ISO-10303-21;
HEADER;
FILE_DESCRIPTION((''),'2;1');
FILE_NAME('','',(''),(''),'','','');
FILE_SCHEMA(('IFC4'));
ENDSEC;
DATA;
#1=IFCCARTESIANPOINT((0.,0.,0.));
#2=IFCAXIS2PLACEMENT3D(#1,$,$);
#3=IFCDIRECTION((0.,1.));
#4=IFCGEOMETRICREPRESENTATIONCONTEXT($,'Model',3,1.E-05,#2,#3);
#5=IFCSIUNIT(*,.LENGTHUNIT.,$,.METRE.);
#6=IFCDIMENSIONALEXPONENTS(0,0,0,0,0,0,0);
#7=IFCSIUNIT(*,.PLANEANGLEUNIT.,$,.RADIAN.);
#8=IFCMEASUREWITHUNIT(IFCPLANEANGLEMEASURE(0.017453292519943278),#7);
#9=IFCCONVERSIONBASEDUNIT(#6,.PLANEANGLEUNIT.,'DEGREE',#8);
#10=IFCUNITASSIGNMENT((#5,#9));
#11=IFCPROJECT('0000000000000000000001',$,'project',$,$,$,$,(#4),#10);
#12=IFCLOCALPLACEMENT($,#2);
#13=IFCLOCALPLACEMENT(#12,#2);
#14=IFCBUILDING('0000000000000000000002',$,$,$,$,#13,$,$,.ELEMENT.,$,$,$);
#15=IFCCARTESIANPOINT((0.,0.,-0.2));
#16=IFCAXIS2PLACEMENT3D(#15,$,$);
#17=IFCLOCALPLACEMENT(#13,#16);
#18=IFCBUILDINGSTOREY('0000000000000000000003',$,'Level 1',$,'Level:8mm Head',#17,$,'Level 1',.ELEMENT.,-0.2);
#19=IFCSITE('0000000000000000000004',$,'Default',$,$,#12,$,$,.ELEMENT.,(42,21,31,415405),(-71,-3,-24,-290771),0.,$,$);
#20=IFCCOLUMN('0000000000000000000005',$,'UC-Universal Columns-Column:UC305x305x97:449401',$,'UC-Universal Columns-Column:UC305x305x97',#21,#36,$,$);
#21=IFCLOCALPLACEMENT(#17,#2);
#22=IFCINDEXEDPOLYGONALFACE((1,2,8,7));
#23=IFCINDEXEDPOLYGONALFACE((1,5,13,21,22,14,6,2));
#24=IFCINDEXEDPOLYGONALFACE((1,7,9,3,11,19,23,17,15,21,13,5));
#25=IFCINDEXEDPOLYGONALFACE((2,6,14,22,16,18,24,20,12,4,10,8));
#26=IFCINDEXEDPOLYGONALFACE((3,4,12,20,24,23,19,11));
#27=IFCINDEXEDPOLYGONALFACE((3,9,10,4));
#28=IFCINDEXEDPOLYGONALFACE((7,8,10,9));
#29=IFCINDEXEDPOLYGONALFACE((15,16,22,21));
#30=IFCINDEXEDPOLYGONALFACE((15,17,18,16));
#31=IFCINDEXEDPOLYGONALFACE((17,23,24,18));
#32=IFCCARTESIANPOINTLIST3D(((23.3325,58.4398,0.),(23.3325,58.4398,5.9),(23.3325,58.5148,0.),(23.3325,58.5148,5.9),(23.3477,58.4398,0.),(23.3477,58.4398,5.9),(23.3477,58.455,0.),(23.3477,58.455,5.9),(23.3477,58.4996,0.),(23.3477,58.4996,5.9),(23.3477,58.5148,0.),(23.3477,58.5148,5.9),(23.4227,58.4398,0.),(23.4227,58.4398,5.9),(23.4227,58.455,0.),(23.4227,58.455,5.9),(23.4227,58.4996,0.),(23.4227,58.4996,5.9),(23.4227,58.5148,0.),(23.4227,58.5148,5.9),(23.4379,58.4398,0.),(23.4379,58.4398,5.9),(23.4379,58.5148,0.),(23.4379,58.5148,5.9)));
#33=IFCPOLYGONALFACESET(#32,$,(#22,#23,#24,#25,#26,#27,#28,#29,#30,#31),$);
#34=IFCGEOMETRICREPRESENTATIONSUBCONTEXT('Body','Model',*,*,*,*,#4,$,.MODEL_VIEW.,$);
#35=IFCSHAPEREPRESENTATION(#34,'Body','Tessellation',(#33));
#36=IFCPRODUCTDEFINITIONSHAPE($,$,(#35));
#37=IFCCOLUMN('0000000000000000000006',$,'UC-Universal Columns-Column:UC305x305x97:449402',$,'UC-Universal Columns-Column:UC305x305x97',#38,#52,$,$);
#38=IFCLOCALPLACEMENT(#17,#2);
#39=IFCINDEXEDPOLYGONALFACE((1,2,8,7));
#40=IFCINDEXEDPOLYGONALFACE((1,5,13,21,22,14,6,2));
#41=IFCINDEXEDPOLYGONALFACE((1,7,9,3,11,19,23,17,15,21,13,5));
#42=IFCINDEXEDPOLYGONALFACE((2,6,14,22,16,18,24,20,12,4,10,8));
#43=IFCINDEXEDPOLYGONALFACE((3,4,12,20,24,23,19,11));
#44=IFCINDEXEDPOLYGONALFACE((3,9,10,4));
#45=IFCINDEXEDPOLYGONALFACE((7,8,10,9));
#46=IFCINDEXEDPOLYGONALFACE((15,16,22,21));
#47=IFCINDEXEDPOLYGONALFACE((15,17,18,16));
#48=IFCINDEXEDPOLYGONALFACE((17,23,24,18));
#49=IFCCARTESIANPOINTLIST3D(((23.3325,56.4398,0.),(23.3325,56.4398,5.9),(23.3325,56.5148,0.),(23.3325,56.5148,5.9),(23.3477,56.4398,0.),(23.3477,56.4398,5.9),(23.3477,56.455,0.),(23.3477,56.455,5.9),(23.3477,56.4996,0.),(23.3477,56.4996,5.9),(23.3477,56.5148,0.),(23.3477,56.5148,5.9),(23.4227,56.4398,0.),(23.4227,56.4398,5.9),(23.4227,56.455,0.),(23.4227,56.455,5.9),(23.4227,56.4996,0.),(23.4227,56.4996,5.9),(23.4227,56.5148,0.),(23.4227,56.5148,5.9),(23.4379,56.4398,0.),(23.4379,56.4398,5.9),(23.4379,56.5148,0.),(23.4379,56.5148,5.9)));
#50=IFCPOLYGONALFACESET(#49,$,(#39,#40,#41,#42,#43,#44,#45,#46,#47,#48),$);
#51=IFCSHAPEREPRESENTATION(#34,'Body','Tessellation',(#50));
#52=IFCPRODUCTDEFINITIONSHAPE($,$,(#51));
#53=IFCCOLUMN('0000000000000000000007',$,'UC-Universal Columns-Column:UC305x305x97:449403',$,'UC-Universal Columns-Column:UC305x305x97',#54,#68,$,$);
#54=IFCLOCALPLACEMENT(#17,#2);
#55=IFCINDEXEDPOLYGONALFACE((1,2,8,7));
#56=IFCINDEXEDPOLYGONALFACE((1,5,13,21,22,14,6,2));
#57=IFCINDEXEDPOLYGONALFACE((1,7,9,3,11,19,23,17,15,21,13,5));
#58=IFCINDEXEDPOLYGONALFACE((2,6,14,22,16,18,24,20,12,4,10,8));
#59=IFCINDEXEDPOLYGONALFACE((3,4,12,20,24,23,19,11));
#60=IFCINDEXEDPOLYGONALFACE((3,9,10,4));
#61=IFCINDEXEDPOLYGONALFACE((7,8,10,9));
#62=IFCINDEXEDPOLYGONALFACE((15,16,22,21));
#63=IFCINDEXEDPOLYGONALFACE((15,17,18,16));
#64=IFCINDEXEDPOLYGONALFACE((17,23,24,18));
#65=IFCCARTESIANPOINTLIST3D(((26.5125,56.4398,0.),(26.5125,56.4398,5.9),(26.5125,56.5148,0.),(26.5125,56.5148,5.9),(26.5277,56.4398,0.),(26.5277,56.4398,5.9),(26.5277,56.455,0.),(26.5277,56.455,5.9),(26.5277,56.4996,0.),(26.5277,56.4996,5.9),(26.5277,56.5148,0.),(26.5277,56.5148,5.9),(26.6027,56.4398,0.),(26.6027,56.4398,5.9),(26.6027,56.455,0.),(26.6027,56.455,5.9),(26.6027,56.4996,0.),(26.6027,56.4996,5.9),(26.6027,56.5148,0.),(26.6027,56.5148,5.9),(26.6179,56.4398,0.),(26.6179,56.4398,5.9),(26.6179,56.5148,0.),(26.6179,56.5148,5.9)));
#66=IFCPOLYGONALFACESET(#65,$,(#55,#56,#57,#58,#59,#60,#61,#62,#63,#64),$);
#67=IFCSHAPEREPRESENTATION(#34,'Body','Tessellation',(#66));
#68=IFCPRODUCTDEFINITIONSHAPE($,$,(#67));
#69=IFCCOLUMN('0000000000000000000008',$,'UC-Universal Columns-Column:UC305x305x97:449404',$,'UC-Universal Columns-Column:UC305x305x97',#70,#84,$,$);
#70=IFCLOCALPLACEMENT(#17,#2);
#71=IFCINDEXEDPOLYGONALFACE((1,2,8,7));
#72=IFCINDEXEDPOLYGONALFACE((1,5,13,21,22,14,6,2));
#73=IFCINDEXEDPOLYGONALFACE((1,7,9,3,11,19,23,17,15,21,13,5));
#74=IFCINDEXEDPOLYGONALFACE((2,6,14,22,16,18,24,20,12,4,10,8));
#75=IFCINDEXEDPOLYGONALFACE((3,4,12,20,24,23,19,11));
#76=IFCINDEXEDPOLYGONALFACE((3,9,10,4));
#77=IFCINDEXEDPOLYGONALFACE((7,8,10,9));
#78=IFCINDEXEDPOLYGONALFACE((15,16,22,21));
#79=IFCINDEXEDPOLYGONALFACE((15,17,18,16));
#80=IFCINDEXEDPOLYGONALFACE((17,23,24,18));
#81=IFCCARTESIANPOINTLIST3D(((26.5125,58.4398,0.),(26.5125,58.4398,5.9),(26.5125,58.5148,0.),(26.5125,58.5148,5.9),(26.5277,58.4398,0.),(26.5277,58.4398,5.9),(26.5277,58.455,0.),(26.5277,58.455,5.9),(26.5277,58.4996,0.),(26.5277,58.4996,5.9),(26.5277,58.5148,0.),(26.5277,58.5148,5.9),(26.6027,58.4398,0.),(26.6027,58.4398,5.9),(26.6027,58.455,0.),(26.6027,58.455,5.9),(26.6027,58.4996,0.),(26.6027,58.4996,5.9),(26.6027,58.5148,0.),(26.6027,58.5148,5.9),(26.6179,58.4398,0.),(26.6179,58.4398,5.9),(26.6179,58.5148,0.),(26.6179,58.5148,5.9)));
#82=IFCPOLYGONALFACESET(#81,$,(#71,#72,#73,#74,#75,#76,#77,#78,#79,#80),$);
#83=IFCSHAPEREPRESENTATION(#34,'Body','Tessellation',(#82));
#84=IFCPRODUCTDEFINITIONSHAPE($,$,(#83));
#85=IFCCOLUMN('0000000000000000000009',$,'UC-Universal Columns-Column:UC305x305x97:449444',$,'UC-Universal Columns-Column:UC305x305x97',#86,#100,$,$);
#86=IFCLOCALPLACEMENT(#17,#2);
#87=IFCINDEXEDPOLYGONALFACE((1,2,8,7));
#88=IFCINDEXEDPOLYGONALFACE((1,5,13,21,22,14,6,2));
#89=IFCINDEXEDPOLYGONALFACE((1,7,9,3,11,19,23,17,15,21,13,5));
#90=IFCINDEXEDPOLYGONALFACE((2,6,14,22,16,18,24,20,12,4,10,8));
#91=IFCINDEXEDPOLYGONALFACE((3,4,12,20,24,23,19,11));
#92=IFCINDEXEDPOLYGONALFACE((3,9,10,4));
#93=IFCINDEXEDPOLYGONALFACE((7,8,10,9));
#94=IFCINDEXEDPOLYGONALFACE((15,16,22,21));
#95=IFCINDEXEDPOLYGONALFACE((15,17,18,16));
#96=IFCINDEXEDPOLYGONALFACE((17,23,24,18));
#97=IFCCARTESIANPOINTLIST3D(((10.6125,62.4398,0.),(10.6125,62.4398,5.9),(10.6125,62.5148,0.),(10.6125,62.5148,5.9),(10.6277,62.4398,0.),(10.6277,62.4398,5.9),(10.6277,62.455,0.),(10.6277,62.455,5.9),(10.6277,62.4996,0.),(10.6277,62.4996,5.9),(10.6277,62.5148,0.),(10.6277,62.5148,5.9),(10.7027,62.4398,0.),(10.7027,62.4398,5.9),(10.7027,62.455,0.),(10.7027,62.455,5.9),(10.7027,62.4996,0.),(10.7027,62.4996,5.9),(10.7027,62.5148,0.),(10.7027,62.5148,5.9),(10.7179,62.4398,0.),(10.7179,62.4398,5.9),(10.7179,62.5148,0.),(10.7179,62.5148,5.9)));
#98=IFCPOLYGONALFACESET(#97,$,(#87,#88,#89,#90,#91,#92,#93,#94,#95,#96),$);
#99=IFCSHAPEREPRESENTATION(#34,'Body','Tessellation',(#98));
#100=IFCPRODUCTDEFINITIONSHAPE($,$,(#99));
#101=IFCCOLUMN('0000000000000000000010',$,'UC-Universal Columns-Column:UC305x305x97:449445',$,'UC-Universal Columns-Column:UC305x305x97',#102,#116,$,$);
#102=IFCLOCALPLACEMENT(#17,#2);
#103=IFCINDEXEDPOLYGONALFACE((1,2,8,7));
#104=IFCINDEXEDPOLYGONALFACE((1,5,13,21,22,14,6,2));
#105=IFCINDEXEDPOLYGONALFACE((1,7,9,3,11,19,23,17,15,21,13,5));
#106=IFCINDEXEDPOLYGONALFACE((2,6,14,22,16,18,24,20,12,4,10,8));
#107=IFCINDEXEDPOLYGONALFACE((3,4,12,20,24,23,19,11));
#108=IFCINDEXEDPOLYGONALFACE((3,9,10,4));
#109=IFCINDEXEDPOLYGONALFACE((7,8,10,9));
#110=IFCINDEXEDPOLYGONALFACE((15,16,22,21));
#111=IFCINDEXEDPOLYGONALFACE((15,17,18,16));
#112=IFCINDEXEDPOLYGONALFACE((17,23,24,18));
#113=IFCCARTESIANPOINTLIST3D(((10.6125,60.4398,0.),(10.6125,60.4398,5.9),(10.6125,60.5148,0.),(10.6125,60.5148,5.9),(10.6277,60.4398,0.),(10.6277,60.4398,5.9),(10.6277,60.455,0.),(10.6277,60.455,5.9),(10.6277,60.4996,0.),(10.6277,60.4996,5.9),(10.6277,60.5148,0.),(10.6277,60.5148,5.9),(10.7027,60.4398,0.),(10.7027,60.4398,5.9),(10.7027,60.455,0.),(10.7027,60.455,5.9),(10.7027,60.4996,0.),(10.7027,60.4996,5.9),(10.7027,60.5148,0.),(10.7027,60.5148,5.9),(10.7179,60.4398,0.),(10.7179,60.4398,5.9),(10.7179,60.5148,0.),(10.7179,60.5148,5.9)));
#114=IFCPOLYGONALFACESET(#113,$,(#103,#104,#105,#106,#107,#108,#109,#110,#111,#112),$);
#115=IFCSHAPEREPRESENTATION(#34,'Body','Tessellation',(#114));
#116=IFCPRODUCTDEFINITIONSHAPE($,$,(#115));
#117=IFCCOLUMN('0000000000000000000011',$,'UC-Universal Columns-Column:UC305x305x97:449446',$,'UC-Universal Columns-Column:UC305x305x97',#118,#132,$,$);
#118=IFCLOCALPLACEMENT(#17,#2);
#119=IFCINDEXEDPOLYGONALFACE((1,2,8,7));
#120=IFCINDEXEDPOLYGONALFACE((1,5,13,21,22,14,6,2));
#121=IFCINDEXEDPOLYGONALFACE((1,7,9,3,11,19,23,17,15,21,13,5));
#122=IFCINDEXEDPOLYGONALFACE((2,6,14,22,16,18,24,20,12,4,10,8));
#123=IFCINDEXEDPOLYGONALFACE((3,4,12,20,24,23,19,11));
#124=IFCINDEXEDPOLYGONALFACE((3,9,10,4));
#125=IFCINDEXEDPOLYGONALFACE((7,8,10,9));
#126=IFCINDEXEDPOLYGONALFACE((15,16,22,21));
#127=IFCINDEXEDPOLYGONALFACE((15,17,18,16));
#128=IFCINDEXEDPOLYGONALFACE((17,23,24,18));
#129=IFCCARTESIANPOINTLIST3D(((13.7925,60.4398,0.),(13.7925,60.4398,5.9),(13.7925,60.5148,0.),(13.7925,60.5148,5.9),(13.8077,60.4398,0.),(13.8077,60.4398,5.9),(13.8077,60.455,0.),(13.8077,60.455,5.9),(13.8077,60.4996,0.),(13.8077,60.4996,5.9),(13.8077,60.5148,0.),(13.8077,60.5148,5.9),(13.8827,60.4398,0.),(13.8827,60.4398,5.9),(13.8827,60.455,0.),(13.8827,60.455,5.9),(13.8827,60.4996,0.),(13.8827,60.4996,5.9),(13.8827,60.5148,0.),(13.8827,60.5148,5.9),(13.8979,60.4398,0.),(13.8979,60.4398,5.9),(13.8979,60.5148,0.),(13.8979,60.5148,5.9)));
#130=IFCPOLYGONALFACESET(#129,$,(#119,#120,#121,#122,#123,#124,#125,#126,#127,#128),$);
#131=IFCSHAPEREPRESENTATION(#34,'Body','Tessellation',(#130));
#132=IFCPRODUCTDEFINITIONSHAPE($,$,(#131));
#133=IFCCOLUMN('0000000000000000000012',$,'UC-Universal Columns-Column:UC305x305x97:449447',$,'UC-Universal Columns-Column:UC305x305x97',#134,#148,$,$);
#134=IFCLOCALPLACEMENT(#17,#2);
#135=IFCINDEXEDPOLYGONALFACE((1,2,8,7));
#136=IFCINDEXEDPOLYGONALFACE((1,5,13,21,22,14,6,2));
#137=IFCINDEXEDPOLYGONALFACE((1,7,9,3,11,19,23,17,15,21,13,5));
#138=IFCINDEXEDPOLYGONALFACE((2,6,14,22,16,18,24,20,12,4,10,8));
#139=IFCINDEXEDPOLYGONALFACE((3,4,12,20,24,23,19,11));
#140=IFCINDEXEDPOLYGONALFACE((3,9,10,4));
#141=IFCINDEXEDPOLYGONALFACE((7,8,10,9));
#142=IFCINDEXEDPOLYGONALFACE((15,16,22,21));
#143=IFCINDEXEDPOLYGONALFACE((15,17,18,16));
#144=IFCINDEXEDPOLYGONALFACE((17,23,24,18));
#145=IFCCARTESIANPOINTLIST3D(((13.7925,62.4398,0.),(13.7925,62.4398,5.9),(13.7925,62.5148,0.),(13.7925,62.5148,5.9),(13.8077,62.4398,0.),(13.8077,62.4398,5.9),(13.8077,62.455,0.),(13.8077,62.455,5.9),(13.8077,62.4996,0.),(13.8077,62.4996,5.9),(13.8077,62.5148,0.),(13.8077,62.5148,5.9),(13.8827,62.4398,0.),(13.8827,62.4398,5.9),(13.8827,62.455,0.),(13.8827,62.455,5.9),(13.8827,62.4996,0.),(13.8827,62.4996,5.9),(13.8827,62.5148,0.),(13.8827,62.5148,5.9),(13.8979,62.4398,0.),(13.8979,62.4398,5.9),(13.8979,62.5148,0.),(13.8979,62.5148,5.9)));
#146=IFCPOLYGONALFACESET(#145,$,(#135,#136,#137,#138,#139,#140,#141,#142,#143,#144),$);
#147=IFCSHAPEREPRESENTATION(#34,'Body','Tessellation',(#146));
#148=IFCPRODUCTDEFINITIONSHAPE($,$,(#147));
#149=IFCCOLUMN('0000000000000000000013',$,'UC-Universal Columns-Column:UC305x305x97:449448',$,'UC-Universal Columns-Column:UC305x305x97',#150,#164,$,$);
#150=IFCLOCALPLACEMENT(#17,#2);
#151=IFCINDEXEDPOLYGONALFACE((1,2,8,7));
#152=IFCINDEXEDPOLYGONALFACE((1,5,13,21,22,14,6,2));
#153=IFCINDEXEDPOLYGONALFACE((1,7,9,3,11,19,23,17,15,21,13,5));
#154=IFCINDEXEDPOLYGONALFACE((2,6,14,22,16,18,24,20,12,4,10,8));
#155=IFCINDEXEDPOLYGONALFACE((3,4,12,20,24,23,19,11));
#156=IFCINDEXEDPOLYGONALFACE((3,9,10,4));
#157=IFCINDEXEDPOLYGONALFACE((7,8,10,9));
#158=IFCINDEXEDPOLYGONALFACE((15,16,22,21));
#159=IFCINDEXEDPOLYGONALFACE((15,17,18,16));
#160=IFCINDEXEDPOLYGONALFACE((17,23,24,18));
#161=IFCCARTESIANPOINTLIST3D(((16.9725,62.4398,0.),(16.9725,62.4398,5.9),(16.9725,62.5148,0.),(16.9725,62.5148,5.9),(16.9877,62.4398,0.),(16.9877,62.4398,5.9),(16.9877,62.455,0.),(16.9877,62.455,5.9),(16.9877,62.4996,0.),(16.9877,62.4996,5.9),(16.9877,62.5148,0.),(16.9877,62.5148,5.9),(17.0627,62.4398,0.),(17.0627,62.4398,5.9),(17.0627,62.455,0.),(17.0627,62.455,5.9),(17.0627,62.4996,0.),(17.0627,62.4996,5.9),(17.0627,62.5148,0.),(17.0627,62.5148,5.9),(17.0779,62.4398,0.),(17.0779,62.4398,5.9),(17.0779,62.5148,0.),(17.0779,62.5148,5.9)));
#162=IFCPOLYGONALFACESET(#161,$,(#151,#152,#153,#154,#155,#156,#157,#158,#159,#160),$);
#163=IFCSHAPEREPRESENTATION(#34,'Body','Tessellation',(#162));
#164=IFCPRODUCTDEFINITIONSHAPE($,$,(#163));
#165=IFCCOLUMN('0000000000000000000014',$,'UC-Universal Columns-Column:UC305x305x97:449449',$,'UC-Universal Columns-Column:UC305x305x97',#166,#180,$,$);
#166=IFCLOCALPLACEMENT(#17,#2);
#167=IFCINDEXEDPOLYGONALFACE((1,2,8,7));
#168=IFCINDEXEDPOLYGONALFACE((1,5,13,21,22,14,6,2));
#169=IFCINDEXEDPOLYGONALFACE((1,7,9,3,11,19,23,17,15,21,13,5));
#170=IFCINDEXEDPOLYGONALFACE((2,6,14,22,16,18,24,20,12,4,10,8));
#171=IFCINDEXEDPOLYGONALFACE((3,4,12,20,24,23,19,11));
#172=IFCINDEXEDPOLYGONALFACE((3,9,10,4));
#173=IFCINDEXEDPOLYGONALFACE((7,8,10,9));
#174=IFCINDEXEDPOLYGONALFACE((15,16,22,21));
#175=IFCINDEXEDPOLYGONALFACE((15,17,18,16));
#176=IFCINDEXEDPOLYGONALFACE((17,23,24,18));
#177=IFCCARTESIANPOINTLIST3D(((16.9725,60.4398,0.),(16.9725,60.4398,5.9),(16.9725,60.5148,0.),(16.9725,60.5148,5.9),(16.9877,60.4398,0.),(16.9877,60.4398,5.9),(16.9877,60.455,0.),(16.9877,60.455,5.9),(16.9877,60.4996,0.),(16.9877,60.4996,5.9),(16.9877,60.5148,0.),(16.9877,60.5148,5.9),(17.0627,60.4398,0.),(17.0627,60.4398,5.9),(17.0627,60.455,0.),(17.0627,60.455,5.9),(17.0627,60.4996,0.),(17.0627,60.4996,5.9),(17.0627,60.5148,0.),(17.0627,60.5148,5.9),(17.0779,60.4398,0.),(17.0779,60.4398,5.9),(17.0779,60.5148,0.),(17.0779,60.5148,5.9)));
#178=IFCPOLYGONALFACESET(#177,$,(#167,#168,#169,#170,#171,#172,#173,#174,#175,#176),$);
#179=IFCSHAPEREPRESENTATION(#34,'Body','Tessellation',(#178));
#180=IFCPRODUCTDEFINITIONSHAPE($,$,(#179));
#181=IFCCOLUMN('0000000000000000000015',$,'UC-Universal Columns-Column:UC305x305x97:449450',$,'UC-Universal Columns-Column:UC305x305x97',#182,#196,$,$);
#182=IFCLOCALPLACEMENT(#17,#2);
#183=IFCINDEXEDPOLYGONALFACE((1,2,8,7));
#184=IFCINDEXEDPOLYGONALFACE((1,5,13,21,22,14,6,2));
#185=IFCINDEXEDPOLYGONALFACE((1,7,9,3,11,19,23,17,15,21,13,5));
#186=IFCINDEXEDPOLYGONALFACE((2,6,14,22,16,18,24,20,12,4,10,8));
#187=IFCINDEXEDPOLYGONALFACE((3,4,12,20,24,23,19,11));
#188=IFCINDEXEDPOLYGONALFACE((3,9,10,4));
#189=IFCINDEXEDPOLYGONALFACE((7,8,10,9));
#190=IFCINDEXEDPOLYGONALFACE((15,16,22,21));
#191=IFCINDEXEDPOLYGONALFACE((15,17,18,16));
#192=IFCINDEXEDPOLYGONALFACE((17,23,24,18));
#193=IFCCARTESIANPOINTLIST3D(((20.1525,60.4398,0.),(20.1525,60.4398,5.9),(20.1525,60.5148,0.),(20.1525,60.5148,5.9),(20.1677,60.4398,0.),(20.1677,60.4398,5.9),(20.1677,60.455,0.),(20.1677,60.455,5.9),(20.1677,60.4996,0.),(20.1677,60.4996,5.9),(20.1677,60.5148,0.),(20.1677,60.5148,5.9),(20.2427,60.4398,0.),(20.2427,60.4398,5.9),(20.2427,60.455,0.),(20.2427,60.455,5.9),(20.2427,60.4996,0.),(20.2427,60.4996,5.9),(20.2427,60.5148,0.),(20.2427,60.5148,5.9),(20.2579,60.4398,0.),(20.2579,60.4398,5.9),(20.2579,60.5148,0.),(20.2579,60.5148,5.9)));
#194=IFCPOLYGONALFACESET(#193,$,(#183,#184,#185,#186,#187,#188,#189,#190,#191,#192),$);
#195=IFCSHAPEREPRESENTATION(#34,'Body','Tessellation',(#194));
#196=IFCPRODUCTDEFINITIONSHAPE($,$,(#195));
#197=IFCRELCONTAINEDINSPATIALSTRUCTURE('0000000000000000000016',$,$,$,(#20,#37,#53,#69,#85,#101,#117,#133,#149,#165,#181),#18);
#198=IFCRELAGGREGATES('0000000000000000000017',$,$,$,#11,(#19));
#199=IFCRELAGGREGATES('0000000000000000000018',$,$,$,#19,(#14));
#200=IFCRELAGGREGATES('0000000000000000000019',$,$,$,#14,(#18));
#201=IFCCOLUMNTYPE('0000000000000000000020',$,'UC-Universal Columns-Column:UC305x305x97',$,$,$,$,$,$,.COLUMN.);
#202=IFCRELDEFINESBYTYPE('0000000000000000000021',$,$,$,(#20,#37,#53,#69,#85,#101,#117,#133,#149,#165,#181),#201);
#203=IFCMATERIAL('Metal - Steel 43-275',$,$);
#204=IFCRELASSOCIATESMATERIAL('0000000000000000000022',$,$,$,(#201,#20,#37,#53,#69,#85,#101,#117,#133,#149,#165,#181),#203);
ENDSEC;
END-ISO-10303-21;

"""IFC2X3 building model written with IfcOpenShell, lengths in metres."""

from ifc_helpers import new_model, entity, si_unit, converted_unit, direction, frame, frame_2d, origin, place, context, subcontext, project, spatial, polyline, circle_curve, parameter, trimmed, segment, composite_curve, outline, extrude, source, transform, mapped, material, type_object, type_shapes, element, save


model = new_model("IFC2X3")

# Units and contexts
model_context = context("Model", 3, precision=1e-05, world=origin(), true_north=direction((0.0, 1.0)))
body_context = subcontext(model_context, "Body", "Model", "MODEL_VIEW")
ifc_project = project(units=[si_unit("LENGTHUNIT", "METRE"), converted_unit("PLANEANGLEUNIT", "DEGREE", entity("IfcPlaneAngleMeasure", 0.017453292519943278), si_unit("PLANEANGLEUNIT", "RADIAN"), dimensions=[0, 0, 0, 0, 0, 0, 0])], contexts=[model_context])

# Site, building, storey
site_placement = place(None, origin())
site = spatial("IfcSite", under=ifc_project, at=site_placement, Name="Default", CompositionType="ELEMENT", RefLatitude=(42, 21, 31, 415405), RefLongitude=(-71, -3, -24, -290771), RefElevation=0.0)
building_placement = place(site_placement, origin())
building = spatial("IfcBuilding", under=site, at=building_placement, CompositionType="ELEMENT")
storey_placement = place(building_placement, frame((0.0, 0.0, -0.2)))
storey = spatial("IfcBuildingStorey", under=building, at=storey_placement, Name="Level 1", ObjectType="Level:8mm Head", LongName="Level 1", CompositionType="ELEMENT", Elevation=-0.2)

# Columns
ifc_material = material(Name="Metal - Steel 43-275")
column_type = type_object("IfcColumnType", Name="UC-Universal Columns-Column:UC305x305x97", PredefinedType="COLUMN", material=ifc_material)
shared_shape = source(origin(), body_context, "Body", "SweptSolid", [
    extrude(outline(composite_curve([segment(polyline([(-0.0375, -0.0375), (0.0375, -0.0375)]), True, "CONTINUOUS"), segment(polyline([(0.0375, -0.0375), (0.0527, -0.0375)]), True, "CONTINUOUS"), segment(trimmed(circle_curve(frame_2d((0.0527, -0.0223), x_axis=(-1.0, 0.0)), 0.0152), [parameter(0.0)], [parameter(90.0)], True, "PARAMETER"), False, "CONTINUOUS"), segment(polyline([(0.0375, -0.0223), (0.0375, 0.0223)]), True, "CONTINUOUS"), segment(trimmed(circle_curve(frame_2d((0.0527, 0.0223), x_axis=(-1.0, 0.0)), 0.0152), [parameter(270.0)], [parameter(0.0)], True, "PARAMETER"), False, "CONTINUOUS"), segment(polyline([(0.0527, 0.0375), (0.0375, 0.0375)]), True, "CONTINUOUS"), segment(polyline([(0.0375, 0.0375), (-0.0375, 0.0375)]), True, "CONTINUOUS"), segment(polyline([(-0.0375, 0.0375), (-0.0527, 0.0375)]), True, "CONTINUOUS"), segment(trimmed(circle_curve(frame_2d((-0.0527, 0.0223), x_axis=(-1.0, 0.0)), 0.0152), [parameter(180.0)], [parameter(270.0)], True, "PARAMETER"), False, "CONTINUOUS"), segment(polyline([(-0.0375, 0.0223), (-0.0375, -0.0223)]), True, "CONTINUOUS"), segment(trimmed(circle_curve(frame_2d((-0.0527, -0.0223), x_axis=(-1.0, 0.0)), 0.0152), [parameter(90.0)], [parameter(180.0)], True, "PARAMETER"), False, "CONTINUOUS"), segment(polyline([(-0.0527, -0.0375), (-0.0375, -0.0375)]), True, "CONTINUOUS")], self_intersect=False)), frame((0.0, 0.0, -0.2), z_axis=(0.0, 0.0, 1.0), x_axis=(-1.0, 0.0, 0.0)), (0.0, 0.0, 1.0), 5.9),
])
type_shapes(column_type, [shared_shape])
for number, where, z_axis, x_axis, name in (
    (1, (23.3852, 58.4773, 0.2), (0.0, 0.0, 1.0), (-1.0, 0.0, 0.0), "UC-Universal Columns-Column:UC305x305x97:449401"),
    (2, (23.3852, 56.4773, 0.2), (0.0, 0.0, 1.0), (-1.0, 0.0, 0.0), "UC-Universal Columns-Column:UC305x305x97:449402"),
    (3, (26.5652, 56.4773, 0.2), (0.0, 0.0, 1.0), (-1.0, 0.0, 0.0), "UC-Universal Columns-Column:UC305x305x97:449403"),
    (4, (26.5652, 58.4773, 0.2), (0.0, 0.0, 1.0), (-1.0, 0.0, 0.0), "UC-Universal Columns-Column:UC305x305x97:449404"),
    (5, (10.6652, 62.4773, 0.2), (0.0, 0.0, 1.0), (-1.0, 0.0, 0.0), "UC-Universal Columns-Column:UC305x305x97:449444"),
    (6, (10.6652, 60.4773, 0.2), (0.0, 0.0, 1.0), (-1.0, 0.0, 0.0), "UC-Universal Columns-Column:UC305x305x97:449445"),
    (7, (13.8452, 60.4773, 0.2), (0.0, 0.0, 1.0), (-1.0, 0.0, 0.0), "UC-Universal Columns-Column:UC305x305x97:449446"),
    (8, (13.8452, 62.4773, 0.2), (0.0, 0.0, 1.0), (-1.0, 0.0, 0.0), "UC-Universal Columns-Column:UC305x305x97:449447"),
    (9, (17.0252, 62.4773, 0.2), (0.0, 0.0, 1.0), (-1.0, 0.0, 0.0), "UC-Universal Columns-Column:UC305x305x97:449448"),
    (10, (17.0252, 60.4773, 0.2), (0.0, 0.0, 1.0), (-1.0, 0.0, 0.0), "UC-Universal Columns-Column:UC305x305x97:449449"),
    (11, (20.2052, 60.4773, 0.2), (0.0, 0.0, 1.0), (-1.0, 0.0, 0.0), "UC-Universal Columns-Column:UC305x305x97:449450"),
):
    element("IfcColumn", number, at=place(storey_placement, frame(where, z_axis=z_axis, x_axis=x_axis)), inside=storey, type_object=column_type, material=ifc_material, Name=name, ObjectType="UC-Universal Columns-Column:UC305x305x97", context=body_context, shape_type="MappedRepresentation", body=[
        mapped(shared_shape, transform((0.0, 0.0, 0.0), scale=1.0)),
    ])

save(model, "model.ifc")
